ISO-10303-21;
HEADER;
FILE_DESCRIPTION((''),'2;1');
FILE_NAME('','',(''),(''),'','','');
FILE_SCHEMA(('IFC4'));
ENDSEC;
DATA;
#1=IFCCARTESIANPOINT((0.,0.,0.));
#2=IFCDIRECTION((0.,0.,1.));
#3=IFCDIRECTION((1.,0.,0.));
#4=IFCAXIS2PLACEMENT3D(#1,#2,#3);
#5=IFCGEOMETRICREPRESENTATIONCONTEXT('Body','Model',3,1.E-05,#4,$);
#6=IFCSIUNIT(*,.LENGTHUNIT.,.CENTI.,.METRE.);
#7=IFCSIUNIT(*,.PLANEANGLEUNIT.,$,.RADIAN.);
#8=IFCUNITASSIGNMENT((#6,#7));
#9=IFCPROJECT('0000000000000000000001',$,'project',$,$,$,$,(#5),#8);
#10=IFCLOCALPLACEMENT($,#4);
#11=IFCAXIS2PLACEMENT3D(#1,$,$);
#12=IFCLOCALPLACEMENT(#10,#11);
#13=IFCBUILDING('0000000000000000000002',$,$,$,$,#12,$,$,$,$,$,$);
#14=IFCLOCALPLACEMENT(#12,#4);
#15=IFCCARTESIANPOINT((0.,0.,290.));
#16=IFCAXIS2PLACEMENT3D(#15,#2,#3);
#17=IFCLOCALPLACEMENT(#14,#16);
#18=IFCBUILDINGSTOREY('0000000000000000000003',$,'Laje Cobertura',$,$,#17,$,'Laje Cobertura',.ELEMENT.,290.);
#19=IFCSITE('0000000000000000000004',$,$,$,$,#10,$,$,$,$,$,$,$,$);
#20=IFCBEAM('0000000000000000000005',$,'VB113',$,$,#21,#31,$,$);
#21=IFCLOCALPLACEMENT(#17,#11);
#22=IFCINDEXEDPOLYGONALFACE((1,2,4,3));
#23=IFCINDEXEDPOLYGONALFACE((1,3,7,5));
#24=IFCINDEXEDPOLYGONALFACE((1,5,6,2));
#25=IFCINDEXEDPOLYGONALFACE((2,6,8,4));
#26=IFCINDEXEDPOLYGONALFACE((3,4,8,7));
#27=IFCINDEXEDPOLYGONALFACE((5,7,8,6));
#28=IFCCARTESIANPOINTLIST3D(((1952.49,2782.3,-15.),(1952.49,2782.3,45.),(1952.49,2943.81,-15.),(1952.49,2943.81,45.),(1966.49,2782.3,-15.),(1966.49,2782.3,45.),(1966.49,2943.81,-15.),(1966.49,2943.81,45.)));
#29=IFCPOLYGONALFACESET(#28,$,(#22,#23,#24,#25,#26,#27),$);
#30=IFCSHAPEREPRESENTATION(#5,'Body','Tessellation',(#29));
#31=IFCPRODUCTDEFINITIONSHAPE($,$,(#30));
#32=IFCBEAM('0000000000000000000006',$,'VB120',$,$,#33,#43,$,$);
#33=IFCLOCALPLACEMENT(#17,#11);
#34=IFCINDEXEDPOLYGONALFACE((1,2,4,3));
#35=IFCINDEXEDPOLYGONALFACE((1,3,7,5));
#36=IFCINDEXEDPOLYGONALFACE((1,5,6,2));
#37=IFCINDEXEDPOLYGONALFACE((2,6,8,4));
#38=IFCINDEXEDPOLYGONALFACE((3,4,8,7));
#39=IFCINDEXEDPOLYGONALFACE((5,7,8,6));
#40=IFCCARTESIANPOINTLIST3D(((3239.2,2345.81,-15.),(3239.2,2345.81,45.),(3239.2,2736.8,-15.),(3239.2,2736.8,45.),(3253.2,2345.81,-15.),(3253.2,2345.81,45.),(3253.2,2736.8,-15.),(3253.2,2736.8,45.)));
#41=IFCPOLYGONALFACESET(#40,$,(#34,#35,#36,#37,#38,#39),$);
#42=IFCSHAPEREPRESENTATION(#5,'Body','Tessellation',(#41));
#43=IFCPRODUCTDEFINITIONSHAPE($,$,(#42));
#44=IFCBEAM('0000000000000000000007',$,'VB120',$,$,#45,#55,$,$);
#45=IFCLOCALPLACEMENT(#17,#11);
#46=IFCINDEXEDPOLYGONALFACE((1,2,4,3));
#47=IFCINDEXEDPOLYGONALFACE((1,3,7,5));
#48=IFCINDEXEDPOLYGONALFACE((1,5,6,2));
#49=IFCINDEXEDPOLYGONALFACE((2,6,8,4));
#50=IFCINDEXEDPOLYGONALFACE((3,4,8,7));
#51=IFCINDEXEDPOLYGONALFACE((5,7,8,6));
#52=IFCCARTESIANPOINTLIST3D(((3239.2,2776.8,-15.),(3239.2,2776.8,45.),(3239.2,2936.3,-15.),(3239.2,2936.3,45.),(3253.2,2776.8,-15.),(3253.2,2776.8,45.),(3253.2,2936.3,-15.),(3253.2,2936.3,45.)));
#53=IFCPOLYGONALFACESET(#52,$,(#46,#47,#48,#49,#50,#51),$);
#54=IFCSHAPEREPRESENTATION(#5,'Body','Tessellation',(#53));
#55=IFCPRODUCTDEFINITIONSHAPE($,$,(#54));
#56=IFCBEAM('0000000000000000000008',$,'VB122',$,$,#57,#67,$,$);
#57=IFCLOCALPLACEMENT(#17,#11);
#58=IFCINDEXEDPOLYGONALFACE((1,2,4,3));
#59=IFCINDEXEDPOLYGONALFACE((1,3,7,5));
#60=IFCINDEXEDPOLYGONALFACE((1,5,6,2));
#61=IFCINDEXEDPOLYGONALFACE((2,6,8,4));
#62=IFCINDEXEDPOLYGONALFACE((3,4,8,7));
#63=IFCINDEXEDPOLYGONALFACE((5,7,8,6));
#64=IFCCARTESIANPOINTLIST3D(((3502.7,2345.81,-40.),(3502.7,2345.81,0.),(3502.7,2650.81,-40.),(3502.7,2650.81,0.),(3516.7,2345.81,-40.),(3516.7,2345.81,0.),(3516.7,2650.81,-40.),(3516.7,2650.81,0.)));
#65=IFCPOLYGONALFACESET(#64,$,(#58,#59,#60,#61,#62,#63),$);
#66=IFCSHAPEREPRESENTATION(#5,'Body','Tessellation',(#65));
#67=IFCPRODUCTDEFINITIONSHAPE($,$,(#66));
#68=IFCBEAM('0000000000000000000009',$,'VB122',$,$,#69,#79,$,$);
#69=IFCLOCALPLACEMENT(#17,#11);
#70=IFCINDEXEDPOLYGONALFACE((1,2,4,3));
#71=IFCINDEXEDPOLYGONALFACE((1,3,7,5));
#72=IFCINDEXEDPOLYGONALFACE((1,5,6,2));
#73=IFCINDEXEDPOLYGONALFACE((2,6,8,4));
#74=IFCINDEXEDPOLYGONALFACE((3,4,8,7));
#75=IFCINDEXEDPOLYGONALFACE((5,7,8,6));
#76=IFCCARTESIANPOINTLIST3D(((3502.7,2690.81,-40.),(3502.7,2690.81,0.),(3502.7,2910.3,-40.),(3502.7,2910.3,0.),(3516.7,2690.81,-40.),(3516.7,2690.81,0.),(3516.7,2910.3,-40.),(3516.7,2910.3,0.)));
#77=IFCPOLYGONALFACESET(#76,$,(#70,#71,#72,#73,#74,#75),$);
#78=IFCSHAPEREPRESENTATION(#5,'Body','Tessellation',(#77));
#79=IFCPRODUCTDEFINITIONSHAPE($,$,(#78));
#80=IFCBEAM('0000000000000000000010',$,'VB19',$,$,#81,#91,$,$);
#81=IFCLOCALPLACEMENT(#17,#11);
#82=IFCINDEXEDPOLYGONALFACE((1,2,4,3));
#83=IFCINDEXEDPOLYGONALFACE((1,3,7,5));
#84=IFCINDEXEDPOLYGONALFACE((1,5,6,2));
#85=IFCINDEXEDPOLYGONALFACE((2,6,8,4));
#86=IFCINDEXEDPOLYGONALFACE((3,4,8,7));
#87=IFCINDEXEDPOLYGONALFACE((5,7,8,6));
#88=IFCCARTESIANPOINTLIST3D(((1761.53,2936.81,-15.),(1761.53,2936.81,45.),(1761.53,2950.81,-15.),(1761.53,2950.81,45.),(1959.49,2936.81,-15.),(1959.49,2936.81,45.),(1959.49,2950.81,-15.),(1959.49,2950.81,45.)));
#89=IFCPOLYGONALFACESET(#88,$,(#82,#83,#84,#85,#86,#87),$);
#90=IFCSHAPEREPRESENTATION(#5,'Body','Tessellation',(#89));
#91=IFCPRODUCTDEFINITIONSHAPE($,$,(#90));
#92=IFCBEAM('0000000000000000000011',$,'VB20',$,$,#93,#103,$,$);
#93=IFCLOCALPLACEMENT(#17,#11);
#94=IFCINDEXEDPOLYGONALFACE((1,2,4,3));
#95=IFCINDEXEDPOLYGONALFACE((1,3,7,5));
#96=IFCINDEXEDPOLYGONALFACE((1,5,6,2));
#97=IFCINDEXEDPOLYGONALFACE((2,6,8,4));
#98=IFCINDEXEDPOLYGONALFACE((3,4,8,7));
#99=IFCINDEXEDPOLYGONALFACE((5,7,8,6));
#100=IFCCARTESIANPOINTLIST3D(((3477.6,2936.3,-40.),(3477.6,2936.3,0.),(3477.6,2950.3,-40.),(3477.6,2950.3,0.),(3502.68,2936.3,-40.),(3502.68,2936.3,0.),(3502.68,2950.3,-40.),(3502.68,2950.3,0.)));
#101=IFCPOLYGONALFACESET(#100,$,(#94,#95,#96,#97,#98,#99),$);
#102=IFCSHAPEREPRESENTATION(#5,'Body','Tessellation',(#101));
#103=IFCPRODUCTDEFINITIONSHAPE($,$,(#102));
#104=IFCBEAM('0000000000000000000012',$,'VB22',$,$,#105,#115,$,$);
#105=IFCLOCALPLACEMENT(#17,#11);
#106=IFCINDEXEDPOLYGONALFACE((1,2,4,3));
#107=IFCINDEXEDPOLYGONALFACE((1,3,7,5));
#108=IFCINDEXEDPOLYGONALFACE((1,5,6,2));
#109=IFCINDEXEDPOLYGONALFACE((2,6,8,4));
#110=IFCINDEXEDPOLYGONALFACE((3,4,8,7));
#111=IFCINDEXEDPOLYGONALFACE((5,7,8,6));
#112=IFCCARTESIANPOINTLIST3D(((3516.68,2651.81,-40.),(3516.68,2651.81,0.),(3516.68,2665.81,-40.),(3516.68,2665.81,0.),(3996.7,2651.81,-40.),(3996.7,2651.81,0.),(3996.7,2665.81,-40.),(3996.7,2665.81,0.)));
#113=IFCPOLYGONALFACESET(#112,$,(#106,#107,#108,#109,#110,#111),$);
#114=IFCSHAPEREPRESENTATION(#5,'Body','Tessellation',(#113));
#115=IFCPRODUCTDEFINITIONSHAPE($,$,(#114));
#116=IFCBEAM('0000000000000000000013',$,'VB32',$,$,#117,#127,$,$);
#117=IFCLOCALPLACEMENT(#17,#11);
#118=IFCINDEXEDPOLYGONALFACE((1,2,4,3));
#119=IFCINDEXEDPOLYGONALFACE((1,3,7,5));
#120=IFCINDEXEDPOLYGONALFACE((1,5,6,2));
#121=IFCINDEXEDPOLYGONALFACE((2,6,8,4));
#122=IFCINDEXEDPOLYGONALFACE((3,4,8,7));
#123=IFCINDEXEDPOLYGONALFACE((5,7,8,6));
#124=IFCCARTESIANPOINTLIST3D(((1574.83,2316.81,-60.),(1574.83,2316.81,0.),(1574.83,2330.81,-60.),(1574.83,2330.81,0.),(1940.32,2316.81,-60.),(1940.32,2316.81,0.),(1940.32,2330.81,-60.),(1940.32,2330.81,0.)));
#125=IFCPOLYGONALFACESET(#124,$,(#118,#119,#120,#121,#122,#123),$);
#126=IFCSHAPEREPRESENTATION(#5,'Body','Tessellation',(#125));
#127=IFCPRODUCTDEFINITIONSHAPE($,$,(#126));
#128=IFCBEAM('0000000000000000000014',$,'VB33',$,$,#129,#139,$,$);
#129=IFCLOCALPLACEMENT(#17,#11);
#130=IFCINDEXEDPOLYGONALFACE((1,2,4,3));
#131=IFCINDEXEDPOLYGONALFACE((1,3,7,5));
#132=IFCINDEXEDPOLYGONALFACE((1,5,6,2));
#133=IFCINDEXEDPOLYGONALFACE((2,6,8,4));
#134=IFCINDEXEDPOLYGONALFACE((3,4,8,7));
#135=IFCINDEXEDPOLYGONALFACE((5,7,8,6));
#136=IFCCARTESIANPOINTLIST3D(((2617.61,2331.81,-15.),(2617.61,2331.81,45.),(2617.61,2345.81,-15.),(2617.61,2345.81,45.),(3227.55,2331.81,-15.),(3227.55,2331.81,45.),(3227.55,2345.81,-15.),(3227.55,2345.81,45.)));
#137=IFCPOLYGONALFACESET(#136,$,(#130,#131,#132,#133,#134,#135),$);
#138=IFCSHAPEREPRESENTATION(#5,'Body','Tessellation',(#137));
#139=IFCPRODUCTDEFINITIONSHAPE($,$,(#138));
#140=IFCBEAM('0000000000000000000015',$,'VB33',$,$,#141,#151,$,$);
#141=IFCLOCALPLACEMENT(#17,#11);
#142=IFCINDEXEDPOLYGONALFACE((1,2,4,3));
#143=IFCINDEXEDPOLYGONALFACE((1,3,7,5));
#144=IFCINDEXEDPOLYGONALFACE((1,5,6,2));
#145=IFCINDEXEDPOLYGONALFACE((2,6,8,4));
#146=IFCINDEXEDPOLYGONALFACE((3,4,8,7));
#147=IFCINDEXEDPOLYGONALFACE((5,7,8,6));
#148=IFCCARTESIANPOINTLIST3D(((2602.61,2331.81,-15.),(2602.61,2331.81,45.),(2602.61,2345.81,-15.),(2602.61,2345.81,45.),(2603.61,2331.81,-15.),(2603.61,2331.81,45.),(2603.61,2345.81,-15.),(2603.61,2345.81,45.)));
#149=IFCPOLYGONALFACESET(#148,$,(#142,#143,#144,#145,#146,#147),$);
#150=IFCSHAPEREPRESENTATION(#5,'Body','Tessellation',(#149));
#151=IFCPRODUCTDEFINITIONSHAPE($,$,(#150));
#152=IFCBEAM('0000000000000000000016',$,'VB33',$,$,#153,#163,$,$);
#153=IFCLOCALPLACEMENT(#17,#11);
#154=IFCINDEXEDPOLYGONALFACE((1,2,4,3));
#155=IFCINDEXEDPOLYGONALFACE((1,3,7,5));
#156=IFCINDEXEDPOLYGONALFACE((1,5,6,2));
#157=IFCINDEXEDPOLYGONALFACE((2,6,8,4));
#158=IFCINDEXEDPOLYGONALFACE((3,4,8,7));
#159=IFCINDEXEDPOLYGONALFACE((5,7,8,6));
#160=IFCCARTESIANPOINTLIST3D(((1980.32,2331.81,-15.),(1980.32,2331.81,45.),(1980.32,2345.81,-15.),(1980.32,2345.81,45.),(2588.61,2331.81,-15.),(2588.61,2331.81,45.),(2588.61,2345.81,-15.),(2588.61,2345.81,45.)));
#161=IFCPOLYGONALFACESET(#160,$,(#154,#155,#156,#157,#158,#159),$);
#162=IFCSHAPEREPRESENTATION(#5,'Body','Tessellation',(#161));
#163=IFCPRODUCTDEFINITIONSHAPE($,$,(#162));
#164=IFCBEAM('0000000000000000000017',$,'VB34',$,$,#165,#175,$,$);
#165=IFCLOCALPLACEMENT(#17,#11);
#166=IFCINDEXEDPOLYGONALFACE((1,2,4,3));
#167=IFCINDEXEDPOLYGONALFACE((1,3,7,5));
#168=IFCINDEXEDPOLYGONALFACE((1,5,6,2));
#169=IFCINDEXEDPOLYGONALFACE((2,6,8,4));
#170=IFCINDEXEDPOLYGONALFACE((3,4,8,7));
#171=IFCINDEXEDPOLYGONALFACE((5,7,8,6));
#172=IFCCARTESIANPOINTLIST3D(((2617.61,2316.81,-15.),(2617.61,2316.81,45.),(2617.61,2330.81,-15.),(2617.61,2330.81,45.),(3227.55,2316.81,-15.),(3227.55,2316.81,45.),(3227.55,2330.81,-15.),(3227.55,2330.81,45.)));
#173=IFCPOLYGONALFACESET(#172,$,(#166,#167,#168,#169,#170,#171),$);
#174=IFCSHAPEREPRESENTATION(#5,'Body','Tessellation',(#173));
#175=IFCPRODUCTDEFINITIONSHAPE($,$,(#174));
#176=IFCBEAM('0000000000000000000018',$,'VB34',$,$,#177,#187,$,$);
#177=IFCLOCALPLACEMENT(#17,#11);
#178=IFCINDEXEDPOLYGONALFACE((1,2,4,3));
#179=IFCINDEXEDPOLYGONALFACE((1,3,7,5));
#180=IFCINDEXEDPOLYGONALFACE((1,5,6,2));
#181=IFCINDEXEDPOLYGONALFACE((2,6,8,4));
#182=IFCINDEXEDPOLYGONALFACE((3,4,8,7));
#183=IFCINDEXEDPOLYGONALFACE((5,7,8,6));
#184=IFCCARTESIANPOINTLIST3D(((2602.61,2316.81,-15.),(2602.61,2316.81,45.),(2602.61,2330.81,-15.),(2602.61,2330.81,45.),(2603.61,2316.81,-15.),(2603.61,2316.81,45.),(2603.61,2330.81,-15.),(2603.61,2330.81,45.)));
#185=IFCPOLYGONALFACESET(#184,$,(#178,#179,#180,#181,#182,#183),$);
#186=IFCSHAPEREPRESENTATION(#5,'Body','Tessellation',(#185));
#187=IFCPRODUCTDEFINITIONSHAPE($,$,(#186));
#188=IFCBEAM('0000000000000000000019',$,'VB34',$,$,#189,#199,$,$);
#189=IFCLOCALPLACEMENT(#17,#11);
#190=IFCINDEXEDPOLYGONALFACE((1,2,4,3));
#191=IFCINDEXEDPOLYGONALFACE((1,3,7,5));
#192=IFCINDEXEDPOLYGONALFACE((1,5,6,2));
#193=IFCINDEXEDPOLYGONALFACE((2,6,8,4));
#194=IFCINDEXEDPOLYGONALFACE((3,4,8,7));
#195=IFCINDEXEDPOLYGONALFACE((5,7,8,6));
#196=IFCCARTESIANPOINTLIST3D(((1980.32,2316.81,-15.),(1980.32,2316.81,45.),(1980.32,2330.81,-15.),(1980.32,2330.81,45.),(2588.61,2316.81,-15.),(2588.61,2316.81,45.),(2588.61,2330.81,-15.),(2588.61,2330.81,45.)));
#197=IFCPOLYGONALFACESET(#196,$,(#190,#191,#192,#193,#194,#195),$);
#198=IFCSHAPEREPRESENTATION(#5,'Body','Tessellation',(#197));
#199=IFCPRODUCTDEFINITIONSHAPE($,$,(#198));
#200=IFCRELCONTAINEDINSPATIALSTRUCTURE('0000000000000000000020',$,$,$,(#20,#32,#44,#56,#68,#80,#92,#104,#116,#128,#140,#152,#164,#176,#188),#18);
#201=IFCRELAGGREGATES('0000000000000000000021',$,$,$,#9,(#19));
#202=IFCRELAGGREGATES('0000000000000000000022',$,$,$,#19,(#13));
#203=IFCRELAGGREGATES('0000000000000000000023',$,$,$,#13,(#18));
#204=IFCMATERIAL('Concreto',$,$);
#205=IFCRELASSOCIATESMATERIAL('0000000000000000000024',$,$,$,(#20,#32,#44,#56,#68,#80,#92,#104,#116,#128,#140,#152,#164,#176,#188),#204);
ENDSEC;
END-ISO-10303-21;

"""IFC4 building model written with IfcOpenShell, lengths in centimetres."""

from ifc_helpers import new_model, si_unit, frame, origin, origin_with_axes, origin_2d_with_axis, place, context, project, spatial, rectangle, extrude, material, element, save


model = new_model("IFC4")

# Units and contexts
model_context = context("Model", 3, precision=1e-05, world=origin_with_axes(), identifier="Body")
ifc_project = project(units=[si_unit("LENGTHUNIT", "METRE", prefix="CENTI"), si_unit("PLANEANGLEUNIT", "RADIAN")], contexts=[model_context])

# Site, building, storey
site_placement = place(None, origin_with_axes())
site = spatial("IfcSite", under=ifc_project, at=site_placement)
building_placement = place(site_placement, origin())
building = spatial("IfcBuilding", under=site, at=building_placement)
placement = place(building_placement, origin_with_axes())
storey_placement = place(placement, frame((0.0, 0.0, 290.0), z_axis=(0.0, 0.0, 1.0), x_axis=(1.0, 0.0, 0.0)))
storey = spatial("IfcBuildingStorey", under=building, at=storey_placement, Name="Laje Cobertura", LongName="Laje Cobertura", CompositionType="ELEMENT", Elevation=290.0)

# Shared definitions
ifc_material = material(Name="Concreto")

# Beams
beam_1_placement = place(storey_placement, frame((1959.49, 2863.05, 45.0), z_axis=(0.0, 0.0, 1.0), x_axis=(1.0, 0.0, 0.0)))
element("IfcBeam", 1, at=beam_1_placement, inside=storey, material=ifc_material, Name="VB113", context=model_context, shape_type="SolidModel", body=[
    extrude(rectangle(XDim=14.0, YDim=60.0, at=origin_2d_with_axis()), frame((0.0, -80.75, -30.0), z_axis=(0.0, 1.0, 0.0), x_axis=(1.0, 0.0, 0.0)), (0.0, 0.0, 1.0), 161.51),
])
beam_2_placement = place(storey_placement, frame((3246.2, 2541.3, 45.0), z_axis=(0.0, 0.0, 1.0), x_axis=(1.0, 0.0, 0.0)))
element("IfcBeam", 2, at=beam_2_placement, inside=storey, material=ifc_material, Name="VB120", context=model_context, shape_type="SolidModel", body=[
    extrude(rectangle(XDim=14.0, YDim=60.0, at=origin_2d_with_axis()), frame((0.0, -195.5, -30.0), z_axis=(0.0, 1.0, 0.0), x_axis=(1.0, 0.0, 0.0)), (0.0, 0.0, 1.0), 390.99),
])
beam_3_placement = place(storey_placement, frame((3246.2, 2856.55, 45.0), z_axis=(0.0, 0.0, 1.0), x_axis=(1.0, 0.0, 0.0)))
element("IfcBeam", 3, at=beam_3_placement, inside=storey, material=ifc_material, Name="VB120", context=model_context, shape_type="SolidModel", body=[
    extrude(rectangle(XDim=14.0, YDim=60.0, at=origin_2d_with_axis()), frame((0.0, -79.75, -30.0), z_axis=(0.0, 1.0, 0.0), x_axis=(1.0, 0.0, 0.0)), (0.0, 0.0, 1.0), 159.5),
])
beam_4_placement = place(storey_placement, frame((3509.7, 2498.31, 0.0), z_axis=(0.0, 0.0, 1.0), x_axis=(1.0, 0.0, 0.0)))
element("IfcBeam", 4, at=beam_4_placement, inside=storey, material=ifc_material, Name="VB122", context=model_context, shape_type="SolidModel", body=[
    extrude(rectangle(XDim=14.0, YDim=40.0, at=origin_2d_with_axis()), frame((0.0, -152.5, -20.0), z_axis=(0.0, 1.0, 0.0), x_axis=(1.0, 0.0, 0.0)), (0.0, 0.0, 1.0), 305.0),
])
beam_5_placement = place(storey_placement, frame((3509.7, 2800.55, 0.0), z_axis=(0.0, 0.0, 1.0), x_axis=(1.0, 0.0, 0.0)))
element("IfcBeam", 5, at=beam_5_placement, inside=storey, material=ifc_material, Name="VB122", context=model_context, shape_type="SolidModel", body=[
    extrude(rectangle(XDim=14.0, YDim=40.0, at=origin_2d_with_axis()), frame((0.0, -109.75, -20.0), z_axis=(0.0, 1.0, 0.0), x_axis=(1.0, 0.0, 0.0)), (0.0, 0.0, 1.0), 219.49),
])
beam_6_placement = place(storey_placement, frame((1860.51, 2943.81, 45.0), z_axis=(0.0, 0.0, 1.0), x_axis=(1.0, 0.0, 0.0)))
element("IfcBeam", 6, at=beam_6_placement, inside=storey, material=ifc_material, Name="VB19", context=model_context, shape_type="SolidModel", body=[
    extrude(rectangle(XDim=14.0, YDim=60.0, at=origin_2d_with_axis()), frame((-98.98, 0.0, -30.0), z_axis=(1.0, 0.0, 0.0), x_axis=(0.0, 1.0, 0.0)), (0.0, 0.0, 1.0), 197.96),
])
beam_7_placement = place(storey_placement, frame((3490.14, 2943.3, 0.0), z_axis=(0.0, 0.0, 1.0), x_axis=(1.0, 0.0, 0.0)))
element("IfcBeam", 7, at=beam_7_placement, inside=storey, material=ifc_material, Name="VB20", context=model_context, shape_type="SolidModel", body=[
    extrude(rectangle(XDim=14.0, YDim=40.0, at=origin_2d_with_axis()), frame((-12.54, 0.0, -20.0), z_axis=(1.0, 0.0, 0.0), x_axis=(0.0, 1.0, 0.0)), (0.0, 0.0, 1.0), 25.08),
])
beam_8_placement = place(storey_placement, frame((3756.69, 2658.81, 0.0), z_axis=(0.0, 0.0, 1.0), x_axis=(1.0, 0.0, 0.0)))
element("IfcBeam", 8, at=beam_8_placement, inside=storey, material=ifc_material, Name="VB22", context=model_context, shape_type="SolidModel", body=[
    extrude(rectangle(XDim=14.0, YDim=40.0, at=origin_2d_with_axis()), frame((-240.01, 0.0, -20.0), z_axis=(1.0, 0.0, 0.0), x_axis=(0.0, 1.0, 0.0)), (0.0, 0.0, 1.0), 480.02),
])
beam_9_placement = place(storey_placement, frame((1757.58, 2323.81, 0.0), z_axis=(0.0, 0.0, 1.0), x_axis=(1.0, 0.0, 0.0)))
element("IfcBeam", 9, at=beam_9_placement, inside=storey, material=ifc_material, Name="VB32", context=model_context, shape_type="SolidModel", body=[
    extrude(rectangle(XDim=14.0, YDim=60.0, at=origin_2d_with_axis()), frame((-182.75, 0.0, -30.0), z_axis=(1.0, 0.0, 0.0), x_axis=(0.0, 1.0, 0.0)), (0.0, 0.0, 1.0), 365.49),
])
beam_10_placement = place(storey_placement, frame((2922.58, 2338.81, 45.0), z_axis=(0.0, 0.0, 1.0), x_axis=(1.0, 0.0, 0.0)))
element("IfcBeam", 10, at=beam_10_placement, inside=storey, material=ifc_material, Name="VB33", context=model_context, shape_type="SolidModel", body=[
    extrude(rectangle(XDim=14.0, YDim=60.0, at=origin_2d_with_axis()), frame((-304.97, 0.0, -30.0), z_axis=(1.0, 0.0, 0.0), x_axis=(0.0, 1.0, 0.0)), (0.0, 0.0, 1.0), 609.94),
])
beam_11_placement = place(storey_placement, frame((2603.11, 2338.81, 45.0), z_axis=(0.0, 0.0, 1.0), x_axis=(1.0, 0.0, 0.0)))
element("IfcBeam", 11, at=beam_11_placement, inside=storey, material=ifc_material, Name="VB33", context=model_context, shape_type="SolidModel", body=[
    extrude(rectangle(XDim=14.0, YDim=60.0, at=origin_2d_with_axis()), frame((-0.5, 0.0, -30.0), z_axis=(1.0, 0.0, 0.0), x_axis=(0.0, 1.0, 0.0)), (0.0, 0.0, 1.0), 1.0),
])
beam_12_placement = place(storey_placement, frame((2284.47, 2338.81, 45.0), z_axis=(0.0, 0.0, 1.0), x_axis=(1.0, 0.0, 0.0)))
element("IfcBeam", 12, at=beam_12_placement, inside=storey, material=ifc_material, Name="VB33", context=model_context, shape_type="SolidModel", body=[
    extrude(rectangle(XDim=14.0, YDim=60.0, at=origin_2d_with_axis()), frame((-304.14, 0.0, -30.0), z_axis=(1.0, 0.0, 0.0), x_axis=(0.0, 1.0, 0.0)), (0.0, 0.0, 1.0), 608.29),
])
beam_13_placement = place(storey_placement, frame((2922.58, 2323.81, 45.0), z_axis=(0.0, 0.0, 1.0), x_axis=(1.0, 0.0, 0.0)))
element("IfcBeam", 13, at=beam_13_placement, inside=storey, material=ifc_material, Name="VB34", context=model_context, shape_type="SolidModel", body=[
    extrude(rectangle(XDim=14.0, YDim=60.0, at=origin_2d_with_axis()), frame((-304.97, 0.0, -30.0), z_axis=(1.0, 0.0, 0.0), x_axis=(0.0, 1.0, 0.0)), (0.0, 0.0, 1.0), 609.94),
])
beam_14_placement = place(storey_placement, frame((2603.11, 2323.81, 45.0), z_axis=(0.0, 0.0, 1.0), x_axis=(1.0, 0.0, 0.0)))
element("IfcBeam", 14, at=beam_14_placement, inside=storey, material=ifc_material, Name="VB34", context=model_context, shape_type="SolidModel", body=[
    extrude(rectangle(XDim=14.0, YDim=60.0, at=origin_2d_with_axis()), frame((-0.5, 0.0, -30.0), z_axis=(1.0, 0.0, 0.0), x_axis=(0.0, 1.0, 0.0)), (0.0, 0.0, 1.0), 1.0),
])
beam_15_placement = place(storey_placement, frame((2284.47, 2323.81, 45.0), z_axis=(0.0, 0.0, 1.0), x_axis=(1.0, 0.0, 0.0)))
element("IfcBeam", 15, at=beam_15_placement, inside=storey, material=ifc_material, Name="VB34", context=model_context, shape_type="SolidModel", body=[
    extrude(rectangle(XDim=14.0, YDim=60.0, at=origin_2d_with_axis()), frame((-304.14, 0.0, -30.0), z_axis=(1.0, 0.0, 0.0), x_axis=(0.0, 1.0, 0.0)), (0.0, 0.0, 1.0), 608.29),
])

save(model, "model.ifc")
